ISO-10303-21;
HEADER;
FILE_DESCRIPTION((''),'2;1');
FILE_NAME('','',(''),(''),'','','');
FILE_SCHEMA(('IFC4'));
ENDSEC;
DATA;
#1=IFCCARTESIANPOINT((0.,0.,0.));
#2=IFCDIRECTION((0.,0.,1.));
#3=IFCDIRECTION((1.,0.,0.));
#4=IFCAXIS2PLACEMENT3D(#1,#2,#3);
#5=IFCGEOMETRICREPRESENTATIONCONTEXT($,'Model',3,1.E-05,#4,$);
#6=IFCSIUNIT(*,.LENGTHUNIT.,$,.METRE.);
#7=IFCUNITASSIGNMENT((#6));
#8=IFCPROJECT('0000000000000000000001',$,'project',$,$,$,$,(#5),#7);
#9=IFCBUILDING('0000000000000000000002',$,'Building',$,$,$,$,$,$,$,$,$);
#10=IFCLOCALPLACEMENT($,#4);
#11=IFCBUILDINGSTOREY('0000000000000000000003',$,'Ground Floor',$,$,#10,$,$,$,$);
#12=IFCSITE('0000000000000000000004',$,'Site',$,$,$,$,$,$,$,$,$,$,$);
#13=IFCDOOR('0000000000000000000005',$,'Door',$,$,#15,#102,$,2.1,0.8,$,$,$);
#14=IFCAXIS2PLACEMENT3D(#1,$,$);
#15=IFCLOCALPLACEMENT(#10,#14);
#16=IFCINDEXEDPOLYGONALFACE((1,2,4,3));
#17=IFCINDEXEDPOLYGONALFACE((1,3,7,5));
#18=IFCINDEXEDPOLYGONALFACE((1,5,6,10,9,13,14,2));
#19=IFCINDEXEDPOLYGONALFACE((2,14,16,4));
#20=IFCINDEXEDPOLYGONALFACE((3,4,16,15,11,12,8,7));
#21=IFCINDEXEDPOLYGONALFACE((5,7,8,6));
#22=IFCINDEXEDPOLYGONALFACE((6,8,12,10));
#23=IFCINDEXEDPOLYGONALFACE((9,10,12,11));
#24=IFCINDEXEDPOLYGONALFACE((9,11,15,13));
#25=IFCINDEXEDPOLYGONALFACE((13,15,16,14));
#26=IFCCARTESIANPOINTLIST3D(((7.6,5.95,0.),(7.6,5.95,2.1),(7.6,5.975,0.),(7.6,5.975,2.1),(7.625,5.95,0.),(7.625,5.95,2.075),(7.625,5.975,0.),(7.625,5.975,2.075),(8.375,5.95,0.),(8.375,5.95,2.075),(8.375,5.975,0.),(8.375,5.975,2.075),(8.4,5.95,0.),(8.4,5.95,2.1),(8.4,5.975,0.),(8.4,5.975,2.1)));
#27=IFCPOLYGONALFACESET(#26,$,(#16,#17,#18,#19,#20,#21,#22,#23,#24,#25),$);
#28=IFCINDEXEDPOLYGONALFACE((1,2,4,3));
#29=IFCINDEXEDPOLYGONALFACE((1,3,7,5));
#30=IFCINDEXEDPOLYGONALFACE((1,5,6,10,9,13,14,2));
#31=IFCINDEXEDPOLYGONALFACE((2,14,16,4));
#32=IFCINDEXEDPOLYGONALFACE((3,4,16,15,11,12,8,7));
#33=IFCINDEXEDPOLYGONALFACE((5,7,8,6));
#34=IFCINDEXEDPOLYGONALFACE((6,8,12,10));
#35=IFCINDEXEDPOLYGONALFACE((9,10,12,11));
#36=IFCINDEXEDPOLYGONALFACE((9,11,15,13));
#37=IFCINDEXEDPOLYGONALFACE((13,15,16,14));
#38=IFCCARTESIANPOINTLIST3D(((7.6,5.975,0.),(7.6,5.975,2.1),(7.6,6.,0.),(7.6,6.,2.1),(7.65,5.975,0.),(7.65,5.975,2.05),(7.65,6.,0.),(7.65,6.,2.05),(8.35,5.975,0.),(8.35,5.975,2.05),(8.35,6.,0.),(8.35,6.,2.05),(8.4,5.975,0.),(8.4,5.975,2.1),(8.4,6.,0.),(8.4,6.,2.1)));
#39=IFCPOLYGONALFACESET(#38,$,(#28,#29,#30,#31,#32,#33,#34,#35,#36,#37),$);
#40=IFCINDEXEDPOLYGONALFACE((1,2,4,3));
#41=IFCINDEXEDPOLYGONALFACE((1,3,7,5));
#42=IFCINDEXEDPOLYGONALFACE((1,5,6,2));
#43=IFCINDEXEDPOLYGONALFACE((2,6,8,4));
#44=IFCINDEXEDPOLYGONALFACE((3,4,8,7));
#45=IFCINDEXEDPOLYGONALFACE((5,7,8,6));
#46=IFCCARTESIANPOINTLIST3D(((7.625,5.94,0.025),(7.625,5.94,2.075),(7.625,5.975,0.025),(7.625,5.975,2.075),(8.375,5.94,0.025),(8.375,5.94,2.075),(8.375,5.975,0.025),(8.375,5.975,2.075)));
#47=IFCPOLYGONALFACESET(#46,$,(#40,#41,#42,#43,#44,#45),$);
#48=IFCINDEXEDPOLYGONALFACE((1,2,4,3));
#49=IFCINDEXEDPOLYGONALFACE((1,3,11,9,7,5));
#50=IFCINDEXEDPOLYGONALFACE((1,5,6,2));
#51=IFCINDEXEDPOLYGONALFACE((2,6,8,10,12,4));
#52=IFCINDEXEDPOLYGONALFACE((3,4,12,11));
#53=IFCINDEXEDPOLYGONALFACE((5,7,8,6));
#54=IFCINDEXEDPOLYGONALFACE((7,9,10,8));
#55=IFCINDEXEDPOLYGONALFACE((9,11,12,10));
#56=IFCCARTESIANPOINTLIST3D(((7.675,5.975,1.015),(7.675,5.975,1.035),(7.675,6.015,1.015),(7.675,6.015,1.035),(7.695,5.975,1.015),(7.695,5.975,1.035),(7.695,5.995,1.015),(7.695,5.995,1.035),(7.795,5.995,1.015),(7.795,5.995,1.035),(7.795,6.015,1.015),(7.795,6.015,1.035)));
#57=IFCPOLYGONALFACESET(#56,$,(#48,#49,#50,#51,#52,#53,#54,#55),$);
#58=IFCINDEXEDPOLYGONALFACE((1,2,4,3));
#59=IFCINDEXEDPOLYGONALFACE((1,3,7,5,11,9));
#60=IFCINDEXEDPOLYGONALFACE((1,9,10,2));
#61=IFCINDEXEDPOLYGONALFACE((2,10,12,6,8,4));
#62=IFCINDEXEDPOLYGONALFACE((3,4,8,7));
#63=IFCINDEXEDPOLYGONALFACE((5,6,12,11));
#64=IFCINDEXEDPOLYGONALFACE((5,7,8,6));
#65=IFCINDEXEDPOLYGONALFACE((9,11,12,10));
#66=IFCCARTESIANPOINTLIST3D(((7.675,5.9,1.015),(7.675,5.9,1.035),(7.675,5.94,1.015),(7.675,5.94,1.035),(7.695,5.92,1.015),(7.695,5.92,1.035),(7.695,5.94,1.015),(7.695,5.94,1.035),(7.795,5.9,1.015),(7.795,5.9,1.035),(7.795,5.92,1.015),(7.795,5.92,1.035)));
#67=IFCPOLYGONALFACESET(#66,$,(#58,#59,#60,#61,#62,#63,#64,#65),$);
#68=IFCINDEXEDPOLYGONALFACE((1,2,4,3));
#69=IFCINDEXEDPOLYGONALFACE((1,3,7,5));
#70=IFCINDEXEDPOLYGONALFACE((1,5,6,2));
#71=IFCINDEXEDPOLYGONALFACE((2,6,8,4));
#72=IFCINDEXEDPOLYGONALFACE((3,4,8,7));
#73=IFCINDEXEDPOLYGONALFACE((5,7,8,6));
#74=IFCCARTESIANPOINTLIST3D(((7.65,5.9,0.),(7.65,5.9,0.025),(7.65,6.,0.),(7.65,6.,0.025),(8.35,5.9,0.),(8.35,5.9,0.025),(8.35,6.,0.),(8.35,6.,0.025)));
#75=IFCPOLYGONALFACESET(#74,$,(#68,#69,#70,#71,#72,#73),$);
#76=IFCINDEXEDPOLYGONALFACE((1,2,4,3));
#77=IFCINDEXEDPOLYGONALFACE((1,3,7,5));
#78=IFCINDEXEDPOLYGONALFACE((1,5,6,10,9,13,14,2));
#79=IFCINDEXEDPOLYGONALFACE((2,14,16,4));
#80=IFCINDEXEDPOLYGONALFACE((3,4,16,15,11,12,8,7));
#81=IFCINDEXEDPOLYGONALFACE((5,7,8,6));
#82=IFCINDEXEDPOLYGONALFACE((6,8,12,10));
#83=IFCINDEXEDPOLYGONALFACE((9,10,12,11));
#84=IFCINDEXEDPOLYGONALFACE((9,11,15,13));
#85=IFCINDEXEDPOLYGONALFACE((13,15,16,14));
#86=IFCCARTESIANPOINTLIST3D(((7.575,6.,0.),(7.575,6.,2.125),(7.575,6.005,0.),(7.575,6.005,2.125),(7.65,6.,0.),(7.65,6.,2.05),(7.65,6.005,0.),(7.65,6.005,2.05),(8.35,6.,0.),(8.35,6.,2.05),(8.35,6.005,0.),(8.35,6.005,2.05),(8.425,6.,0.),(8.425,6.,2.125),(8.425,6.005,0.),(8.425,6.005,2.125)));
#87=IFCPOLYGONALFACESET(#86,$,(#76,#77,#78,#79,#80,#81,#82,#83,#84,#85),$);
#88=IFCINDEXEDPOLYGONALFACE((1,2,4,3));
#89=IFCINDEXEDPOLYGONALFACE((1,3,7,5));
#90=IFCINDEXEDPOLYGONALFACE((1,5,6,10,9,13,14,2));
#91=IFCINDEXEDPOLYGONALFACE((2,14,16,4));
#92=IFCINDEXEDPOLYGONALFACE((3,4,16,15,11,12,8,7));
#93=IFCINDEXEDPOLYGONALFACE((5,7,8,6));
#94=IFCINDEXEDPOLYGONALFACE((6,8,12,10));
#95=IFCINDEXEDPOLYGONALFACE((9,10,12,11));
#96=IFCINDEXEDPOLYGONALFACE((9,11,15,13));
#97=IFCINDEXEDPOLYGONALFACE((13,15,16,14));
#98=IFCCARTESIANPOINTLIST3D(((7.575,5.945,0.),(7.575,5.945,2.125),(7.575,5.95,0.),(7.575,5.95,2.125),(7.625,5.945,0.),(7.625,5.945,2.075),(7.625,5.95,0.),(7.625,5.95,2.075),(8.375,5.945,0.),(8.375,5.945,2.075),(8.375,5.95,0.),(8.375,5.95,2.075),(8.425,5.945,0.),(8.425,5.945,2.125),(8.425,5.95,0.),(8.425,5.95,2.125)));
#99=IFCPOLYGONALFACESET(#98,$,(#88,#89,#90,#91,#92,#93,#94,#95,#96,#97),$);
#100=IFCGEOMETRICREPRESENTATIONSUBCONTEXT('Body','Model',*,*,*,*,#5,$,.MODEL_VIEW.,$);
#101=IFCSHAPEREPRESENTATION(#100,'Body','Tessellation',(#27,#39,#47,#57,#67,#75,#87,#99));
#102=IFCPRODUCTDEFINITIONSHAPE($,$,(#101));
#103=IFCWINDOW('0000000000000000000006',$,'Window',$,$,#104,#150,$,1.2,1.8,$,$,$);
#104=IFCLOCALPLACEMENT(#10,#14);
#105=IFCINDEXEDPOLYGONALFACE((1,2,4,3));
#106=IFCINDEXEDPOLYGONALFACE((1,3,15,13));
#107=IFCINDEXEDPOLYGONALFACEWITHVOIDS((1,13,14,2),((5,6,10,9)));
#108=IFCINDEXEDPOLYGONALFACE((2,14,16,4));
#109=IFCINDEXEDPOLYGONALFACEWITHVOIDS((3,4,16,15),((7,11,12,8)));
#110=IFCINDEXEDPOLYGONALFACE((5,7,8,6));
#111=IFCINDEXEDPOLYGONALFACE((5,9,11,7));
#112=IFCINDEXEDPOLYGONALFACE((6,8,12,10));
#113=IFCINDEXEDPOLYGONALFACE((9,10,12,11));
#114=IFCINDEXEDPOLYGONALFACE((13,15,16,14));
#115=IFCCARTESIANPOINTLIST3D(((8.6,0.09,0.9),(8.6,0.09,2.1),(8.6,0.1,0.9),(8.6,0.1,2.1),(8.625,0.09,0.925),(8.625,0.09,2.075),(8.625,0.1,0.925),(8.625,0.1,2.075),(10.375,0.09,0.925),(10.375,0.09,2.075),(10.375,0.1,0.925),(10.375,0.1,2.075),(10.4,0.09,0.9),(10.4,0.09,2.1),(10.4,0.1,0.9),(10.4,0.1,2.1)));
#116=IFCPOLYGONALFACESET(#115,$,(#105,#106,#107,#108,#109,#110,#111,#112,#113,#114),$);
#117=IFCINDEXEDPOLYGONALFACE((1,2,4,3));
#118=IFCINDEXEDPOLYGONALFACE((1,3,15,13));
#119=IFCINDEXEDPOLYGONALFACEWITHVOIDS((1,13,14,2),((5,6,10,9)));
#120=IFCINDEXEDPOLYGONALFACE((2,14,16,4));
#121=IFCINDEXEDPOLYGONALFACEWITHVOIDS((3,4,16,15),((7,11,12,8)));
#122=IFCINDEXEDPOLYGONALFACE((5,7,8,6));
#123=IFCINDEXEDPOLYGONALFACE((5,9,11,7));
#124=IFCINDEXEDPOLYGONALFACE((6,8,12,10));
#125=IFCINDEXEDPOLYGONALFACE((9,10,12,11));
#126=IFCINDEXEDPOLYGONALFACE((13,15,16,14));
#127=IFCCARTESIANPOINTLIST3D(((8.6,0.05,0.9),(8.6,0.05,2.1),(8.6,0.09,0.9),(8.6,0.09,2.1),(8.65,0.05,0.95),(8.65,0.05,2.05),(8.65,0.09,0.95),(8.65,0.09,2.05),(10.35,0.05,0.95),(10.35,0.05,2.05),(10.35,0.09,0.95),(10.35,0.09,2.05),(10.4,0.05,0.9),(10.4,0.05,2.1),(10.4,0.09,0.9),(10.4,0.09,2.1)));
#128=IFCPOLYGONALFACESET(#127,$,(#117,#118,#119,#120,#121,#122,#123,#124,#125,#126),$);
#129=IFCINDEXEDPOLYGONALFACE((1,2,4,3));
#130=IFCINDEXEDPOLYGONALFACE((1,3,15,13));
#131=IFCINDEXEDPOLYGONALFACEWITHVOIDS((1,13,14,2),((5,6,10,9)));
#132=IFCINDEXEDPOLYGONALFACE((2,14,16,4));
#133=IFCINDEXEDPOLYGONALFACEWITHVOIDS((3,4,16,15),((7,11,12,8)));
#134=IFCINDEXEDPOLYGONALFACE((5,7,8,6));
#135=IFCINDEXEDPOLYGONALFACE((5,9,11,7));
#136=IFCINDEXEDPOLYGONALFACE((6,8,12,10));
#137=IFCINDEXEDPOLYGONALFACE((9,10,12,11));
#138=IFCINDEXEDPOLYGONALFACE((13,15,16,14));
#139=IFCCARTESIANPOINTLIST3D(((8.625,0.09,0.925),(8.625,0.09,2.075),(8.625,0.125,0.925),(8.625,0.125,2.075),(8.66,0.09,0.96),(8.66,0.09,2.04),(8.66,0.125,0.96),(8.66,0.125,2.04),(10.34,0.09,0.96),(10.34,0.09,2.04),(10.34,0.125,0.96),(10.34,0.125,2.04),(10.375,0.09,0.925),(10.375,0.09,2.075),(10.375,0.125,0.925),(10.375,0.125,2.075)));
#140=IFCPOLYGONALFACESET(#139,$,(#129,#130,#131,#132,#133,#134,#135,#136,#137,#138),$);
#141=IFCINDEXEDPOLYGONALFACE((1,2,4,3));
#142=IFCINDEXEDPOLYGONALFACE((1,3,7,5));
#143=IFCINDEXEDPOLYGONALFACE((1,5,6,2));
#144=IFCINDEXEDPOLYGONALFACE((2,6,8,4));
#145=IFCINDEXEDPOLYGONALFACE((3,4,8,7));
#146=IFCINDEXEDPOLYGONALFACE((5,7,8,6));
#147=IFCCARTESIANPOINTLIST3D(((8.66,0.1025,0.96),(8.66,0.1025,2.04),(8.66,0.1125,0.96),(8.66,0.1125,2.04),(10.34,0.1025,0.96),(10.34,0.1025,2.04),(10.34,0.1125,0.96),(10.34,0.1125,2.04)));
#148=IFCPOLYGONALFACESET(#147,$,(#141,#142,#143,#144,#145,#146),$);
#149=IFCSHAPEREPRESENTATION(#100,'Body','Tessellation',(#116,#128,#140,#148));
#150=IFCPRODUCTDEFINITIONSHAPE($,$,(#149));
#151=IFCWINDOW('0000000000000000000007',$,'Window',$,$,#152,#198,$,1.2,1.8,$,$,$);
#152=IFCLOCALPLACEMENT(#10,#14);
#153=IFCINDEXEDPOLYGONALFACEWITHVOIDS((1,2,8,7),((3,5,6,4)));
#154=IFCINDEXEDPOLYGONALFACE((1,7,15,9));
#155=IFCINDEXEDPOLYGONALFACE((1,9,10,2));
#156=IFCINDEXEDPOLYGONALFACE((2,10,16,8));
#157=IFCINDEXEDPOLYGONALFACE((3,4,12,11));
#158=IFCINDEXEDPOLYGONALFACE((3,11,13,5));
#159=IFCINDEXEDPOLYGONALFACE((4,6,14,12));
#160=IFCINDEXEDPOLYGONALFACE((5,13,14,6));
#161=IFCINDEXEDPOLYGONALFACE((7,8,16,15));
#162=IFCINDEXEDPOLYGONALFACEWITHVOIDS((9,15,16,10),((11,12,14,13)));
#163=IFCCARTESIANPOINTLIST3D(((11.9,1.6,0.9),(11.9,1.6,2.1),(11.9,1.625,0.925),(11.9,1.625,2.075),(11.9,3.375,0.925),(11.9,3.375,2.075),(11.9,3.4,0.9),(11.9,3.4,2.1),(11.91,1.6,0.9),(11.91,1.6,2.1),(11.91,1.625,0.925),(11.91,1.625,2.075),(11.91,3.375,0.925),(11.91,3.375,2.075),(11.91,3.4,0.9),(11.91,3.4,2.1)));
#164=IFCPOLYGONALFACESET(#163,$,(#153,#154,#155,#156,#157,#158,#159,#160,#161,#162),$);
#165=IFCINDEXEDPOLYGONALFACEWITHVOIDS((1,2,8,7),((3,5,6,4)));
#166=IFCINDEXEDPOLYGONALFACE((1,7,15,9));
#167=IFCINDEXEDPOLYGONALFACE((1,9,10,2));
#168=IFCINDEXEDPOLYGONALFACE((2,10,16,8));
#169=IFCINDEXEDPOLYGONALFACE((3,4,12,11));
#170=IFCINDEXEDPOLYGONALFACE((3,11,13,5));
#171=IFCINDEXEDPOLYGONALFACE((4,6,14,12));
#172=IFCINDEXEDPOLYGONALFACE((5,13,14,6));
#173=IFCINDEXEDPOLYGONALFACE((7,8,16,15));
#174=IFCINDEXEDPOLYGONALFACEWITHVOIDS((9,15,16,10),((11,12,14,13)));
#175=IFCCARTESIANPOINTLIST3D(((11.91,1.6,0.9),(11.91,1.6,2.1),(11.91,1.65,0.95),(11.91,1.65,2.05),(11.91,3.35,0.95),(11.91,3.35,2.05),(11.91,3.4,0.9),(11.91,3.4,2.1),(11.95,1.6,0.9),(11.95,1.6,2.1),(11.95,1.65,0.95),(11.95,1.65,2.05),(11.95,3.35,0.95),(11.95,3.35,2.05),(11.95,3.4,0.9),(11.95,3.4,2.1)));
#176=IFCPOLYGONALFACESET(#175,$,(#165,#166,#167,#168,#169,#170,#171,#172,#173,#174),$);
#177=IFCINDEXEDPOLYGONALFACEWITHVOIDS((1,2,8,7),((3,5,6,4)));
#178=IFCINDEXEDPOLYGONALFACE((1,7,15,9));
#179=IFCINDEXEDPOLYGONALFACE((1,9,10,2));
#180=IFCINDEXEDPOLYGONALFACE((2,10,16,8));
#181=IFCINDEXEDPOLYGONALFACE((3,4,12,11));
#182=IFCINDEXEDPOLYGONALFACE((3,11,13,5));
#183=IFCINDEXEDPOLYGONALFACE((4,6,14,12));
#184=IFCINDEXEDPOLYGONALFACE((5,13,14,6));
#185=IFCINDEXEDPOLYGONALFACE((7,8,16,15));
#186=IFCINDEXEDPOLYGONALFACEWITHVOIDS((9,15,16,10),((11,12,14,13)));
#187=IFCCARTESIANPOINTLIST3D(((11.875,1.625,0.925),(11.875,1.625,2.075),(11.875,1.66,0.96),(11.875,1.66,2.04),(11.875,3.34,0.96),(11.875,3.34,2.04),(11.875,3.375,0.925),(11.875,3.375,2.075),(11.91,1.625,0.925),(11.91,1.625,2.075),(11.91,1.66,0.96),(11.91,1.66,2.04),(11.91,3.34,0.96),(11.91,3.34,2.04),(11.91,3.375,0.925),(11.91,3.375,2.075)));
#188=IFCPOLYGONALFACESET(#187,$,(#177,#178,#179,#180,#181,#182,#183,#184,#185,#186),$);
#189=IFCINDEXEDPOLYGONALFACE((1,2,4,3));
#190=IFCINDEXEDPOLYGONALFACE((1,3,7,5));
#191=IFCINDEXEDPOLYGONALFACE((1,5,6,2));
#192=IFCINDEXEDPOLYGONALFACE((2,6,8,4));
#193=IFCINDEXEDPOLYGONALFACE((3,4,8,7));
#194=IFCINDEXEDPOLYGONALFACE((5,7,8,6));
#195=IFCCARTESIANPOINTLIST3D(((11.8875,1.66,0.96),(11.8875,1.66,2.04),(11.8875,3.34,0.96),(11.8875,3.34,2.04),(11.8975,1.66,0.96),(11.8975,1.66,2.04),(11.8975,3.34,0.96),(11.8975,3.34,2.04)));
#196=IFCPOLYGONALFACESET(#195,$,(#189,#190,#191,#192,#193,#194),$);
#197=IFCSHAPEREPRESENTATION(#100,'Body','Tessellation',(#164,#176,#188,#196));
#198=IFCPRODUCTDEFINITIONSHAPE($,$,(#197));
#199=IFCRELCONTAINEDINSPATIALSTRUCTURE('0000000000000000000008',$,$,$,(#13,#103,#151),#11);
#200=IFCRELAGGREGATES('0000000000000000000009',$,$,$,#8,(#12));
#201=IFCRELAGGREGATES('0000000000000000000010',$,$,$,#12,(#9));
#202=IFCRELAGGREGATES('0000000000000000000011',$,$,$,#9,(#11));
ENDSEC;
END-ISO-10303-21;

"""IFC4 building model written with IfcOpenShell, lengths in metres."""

from ifc_helpers import new_model, si_unit, frame, origin_with_axes, place, context, subcontext, project, spatial, line, indexed_curve, outline, extrude, element, save


model = new_model("IFC4")

# Units and contexts
model_context = context("Model", 3, precision=1e-05, world=origin_with_axes())
body_context = subcontext(model_context, "Body", "Model", "MODEL_VIEW")
ifc_project = project(units=[si_unit("LENGTHUNIT", "METRE")], contexts=[model_context])

# Site, building, storey
site = spatial("IfcSite", under=ifc_project, Name="Site")
building = spatial("IfcBuilding", under=site, Name="Building")
storey_placement = place(None, origin_with_axes())
storey = spatial("IfcBuildingStorey", under=building, at=storey_placement, Name="Ground Floor")

# Door
door_1_placement = place(storey_placement, frame((8.4, 6.0, 0.0), z_axis=(0.0, 0.0, 1.0), x_axis=(-1.0, 0.0, 0.0)))
element("IfcDoor", 1, at=door_1_placement, inside=storey, Name="Door", OverallHeight=2.1, OverallWidth=0.8, context=body_context, shape_type="SweptSolid", body=[
    extrude(outline(indexed_curve([(0.0, 0.0), (0.0, 2.1), (0.8, 2.1), (0.8, 0.0), (0.775, 0.0), (0.775, 2.075), (0.025, 2.075), (0.025, 0.0)], segments=[line(1, 2, 3, 4, 5, 6, 7, 8, 1)])), frame((0.0, 0.025, 0.0), z_axis=(0.0, -1.0, 0.0), x_axis=(1.0, 0.0, 0.0)), (0.0, 0.0, -1.0), 0.025),
    extrude(outline(indexed_curve([(0.0, 0.0), (0.0, 2.1), (0.8, 2.1), (0.8, 0.0), (0.75, 0.0), (0.75, 2.05), (0.05, 2.05), (0.05, 0.0)], segments=[line(1, 2, 3, 4, 5, 6, 7, 8, 1)])), frame((0.0, 0.0, 0.0), z_axis=(0.0, -1.0, 0.0), x_axis=(1.0, 0.0, 0.0)), (0.0, 0.0, -1.0), 0.025),
    extrude(outline(indexed_curve([(0.0, 0.0), (0.75, 0.0), (0.75, 0.035), (0.0, 0.035)], segments=[line(1, 2, 3, 4, 1)])), frame((0.025, 0.025, 0.025), z_axis=(0.0, 0.0, 1.0), x_axis=(1.0, 0.0, 0.0)), (0.0, 0.0, 1.0), 2.05),
    extrude(outline(indexed_curve([(0.0, 0.0), (0.0, -0.04), (-0.12, -0.04), (-0.12, -0.02), (-0.02, -0.02), (-0.02, 0.0)], segments=[line(1, 2, 3, 4, 5, 6, 1)])), frame((0.725, 0.025, 1.015), z_axis=(0.0, 0.0, 1.0), x_axis=(1.0, 0.0, 0.0)), (0.0, 0.0, 1.0), 0.02),
    extrude(outline(indexed_curve([(0.0, 0.0), (0.0, 0.04), (-0.12, 0.04), (-0.12, 0.02), (-0.02, 0.02), (-0.02, 0.0)], segments=[line(1, 2, 3, 4, 5, 6, 1)])), frame((0.725, 0.06, 1.015), z_axis=(0.0, 0.0, 1.0), x_axis=(1.0, 0.0, 0.0)), (0.0, 0.0, 1.0), 0.02),
    extrude(outline(indexed_curve([(0.0, 0.0), (0.7, 0.0), (0.7, 0.1), (0.0, 0.1)], segments=[line(1, 2, 3, 4, 1)])), frame((0.05, 0.0, 0.0), z_axis=(0.0, 0.0, 1.0), x_axis=(1.0, 0.0, 0.0)), (0.0, 0.0, 1.0), 0.025),
    extrude(outline(indexed_curve([(0.0, 0.0), (0.0, 2.125), (0.85, 2.125), (0.85, 0.0), (0.775, 0.0), (0.775, 2.05), (0.075, 2.05), (0.075, 0.0)], segments=[line(1, 2, 3, 4, 5, 6, 7, 8, 1)])), frame((-0.025, -0.005, 0.0), z_axis=(0.0, -1.0, 0.0), x_axis=(1.0, 0.0, 0.0)), (0.0, 0.0, -1.0), 0.005),
    extrude(outline(indexed_curve([(0.0, 0.0), (0.0, 2.125), (0.85, 2.125), (0.85, 0.0), (0.8, 0.0), (0.8, 2.075), (0.05, 2.075), (0.05, 0.0)], segments=[line(1, 2, 3, 4, 5, 6, 7, 8, 1)])), frame((-0.025, 0.05, 0.0), z_axis=(0.0, -1.0, 0.0), x_axis=(1.0, 0.0, 0.0)), (0.0, 0.0, -1.0), 0.005),
])

# Windows
for number, where, z_axis, x_axis, name in (
    (2, (8.6, 0.0, 0.9), (0.0, 0.0, 1.0), (1.0, 0.0, 0.0), "Window"),
    (3, (12.0, 1.6, 0.9), (0.0, 0.0, 1.0), (0.0, 1.0, 0.0), "Window"),
):
    element("IfcWindow", number, at=place(storey_placement, frame(where, z_axis=z_axis, x_axis=x_axis)), inside=storey, Name=name, OverallHeight=1.2, OverallWidth=1.8, context=body_context, shape_type="SweptSolid", body=[
        extrude(outline(indexed_curve([(0.0, 0.0), (1.8, 0.0), (1.8, 1.2), (0.0, 1.2)], segments=[line(1, 2, 3, 4, 1)]), holes=[indexed_curve([(0.025, 0.025), (1.775, 0.025), (1.775, 1.175), (0.025, 1.175)], segments=[line(1, 2, 3, 4, 1)])]), frame((0.0, 0.09, 0.0), z_axis=(0.0, -1.0, 0.0), x_axis=(1.0, 0.0, 0.0)), (0.0, 0.0, -1.0), 0.01),
        extrude(outline(indexed_curve([(0.0, 0.0), (1.8, 0.0), (1.8, 1.2), (0.0, 1.2)], segments=[line(1, 2, 3, 4, 1)]), holes=[indexed_curve([(0.05, 0.05), (1.75, 0.05), (1.75, 1.15), (0.05, 1.15)], segments=[line(1, 2, 3, 4, 1)])]), frame((0.0, 0.05, 0.0), z_axis=(0.0, -1.0, 0.0), x_axis=(1.0, 0.0, 0.0)), (0.0, 0.0, -1.0), 0.04),
        extrude(outline(indexed_curve([(0.0, 0.0), (1.75, 0.0), (1.75, 1.15), (0.0, 1.15)], segments=[line(1, 2, 3, 4, 1)]), holes=[indexed_curve([(0.035, 0.035), (1.715, 0.035), (1.715, 1.115), (0.035, 1.115)], segments=[line(1, 2, 3, 4, 1)])]), frame((0.025, 0.09, 0.025), z_axis=(0.0, -1.0, 0.0), x_axis=(1.0, 0.0, 0.0)), (0.0, 0.0, -1.0), 0.035),
        extrude(outline(indexed_curve([(0.035, 0.035), (1.715, 0.035), (1.715, 1.115), (0.035, 1.115)], segments=[line(1, 2, 3, 4, 1)])), frame((0.025, 0.1025, 0.025), z_axis=(0.0, -1.0, 0.0), x_axis=(1.0, 0.0, 0.0)), (0.0, 0.0, -1.0), 0.01),
    ])

save(model, "model.ifc")
